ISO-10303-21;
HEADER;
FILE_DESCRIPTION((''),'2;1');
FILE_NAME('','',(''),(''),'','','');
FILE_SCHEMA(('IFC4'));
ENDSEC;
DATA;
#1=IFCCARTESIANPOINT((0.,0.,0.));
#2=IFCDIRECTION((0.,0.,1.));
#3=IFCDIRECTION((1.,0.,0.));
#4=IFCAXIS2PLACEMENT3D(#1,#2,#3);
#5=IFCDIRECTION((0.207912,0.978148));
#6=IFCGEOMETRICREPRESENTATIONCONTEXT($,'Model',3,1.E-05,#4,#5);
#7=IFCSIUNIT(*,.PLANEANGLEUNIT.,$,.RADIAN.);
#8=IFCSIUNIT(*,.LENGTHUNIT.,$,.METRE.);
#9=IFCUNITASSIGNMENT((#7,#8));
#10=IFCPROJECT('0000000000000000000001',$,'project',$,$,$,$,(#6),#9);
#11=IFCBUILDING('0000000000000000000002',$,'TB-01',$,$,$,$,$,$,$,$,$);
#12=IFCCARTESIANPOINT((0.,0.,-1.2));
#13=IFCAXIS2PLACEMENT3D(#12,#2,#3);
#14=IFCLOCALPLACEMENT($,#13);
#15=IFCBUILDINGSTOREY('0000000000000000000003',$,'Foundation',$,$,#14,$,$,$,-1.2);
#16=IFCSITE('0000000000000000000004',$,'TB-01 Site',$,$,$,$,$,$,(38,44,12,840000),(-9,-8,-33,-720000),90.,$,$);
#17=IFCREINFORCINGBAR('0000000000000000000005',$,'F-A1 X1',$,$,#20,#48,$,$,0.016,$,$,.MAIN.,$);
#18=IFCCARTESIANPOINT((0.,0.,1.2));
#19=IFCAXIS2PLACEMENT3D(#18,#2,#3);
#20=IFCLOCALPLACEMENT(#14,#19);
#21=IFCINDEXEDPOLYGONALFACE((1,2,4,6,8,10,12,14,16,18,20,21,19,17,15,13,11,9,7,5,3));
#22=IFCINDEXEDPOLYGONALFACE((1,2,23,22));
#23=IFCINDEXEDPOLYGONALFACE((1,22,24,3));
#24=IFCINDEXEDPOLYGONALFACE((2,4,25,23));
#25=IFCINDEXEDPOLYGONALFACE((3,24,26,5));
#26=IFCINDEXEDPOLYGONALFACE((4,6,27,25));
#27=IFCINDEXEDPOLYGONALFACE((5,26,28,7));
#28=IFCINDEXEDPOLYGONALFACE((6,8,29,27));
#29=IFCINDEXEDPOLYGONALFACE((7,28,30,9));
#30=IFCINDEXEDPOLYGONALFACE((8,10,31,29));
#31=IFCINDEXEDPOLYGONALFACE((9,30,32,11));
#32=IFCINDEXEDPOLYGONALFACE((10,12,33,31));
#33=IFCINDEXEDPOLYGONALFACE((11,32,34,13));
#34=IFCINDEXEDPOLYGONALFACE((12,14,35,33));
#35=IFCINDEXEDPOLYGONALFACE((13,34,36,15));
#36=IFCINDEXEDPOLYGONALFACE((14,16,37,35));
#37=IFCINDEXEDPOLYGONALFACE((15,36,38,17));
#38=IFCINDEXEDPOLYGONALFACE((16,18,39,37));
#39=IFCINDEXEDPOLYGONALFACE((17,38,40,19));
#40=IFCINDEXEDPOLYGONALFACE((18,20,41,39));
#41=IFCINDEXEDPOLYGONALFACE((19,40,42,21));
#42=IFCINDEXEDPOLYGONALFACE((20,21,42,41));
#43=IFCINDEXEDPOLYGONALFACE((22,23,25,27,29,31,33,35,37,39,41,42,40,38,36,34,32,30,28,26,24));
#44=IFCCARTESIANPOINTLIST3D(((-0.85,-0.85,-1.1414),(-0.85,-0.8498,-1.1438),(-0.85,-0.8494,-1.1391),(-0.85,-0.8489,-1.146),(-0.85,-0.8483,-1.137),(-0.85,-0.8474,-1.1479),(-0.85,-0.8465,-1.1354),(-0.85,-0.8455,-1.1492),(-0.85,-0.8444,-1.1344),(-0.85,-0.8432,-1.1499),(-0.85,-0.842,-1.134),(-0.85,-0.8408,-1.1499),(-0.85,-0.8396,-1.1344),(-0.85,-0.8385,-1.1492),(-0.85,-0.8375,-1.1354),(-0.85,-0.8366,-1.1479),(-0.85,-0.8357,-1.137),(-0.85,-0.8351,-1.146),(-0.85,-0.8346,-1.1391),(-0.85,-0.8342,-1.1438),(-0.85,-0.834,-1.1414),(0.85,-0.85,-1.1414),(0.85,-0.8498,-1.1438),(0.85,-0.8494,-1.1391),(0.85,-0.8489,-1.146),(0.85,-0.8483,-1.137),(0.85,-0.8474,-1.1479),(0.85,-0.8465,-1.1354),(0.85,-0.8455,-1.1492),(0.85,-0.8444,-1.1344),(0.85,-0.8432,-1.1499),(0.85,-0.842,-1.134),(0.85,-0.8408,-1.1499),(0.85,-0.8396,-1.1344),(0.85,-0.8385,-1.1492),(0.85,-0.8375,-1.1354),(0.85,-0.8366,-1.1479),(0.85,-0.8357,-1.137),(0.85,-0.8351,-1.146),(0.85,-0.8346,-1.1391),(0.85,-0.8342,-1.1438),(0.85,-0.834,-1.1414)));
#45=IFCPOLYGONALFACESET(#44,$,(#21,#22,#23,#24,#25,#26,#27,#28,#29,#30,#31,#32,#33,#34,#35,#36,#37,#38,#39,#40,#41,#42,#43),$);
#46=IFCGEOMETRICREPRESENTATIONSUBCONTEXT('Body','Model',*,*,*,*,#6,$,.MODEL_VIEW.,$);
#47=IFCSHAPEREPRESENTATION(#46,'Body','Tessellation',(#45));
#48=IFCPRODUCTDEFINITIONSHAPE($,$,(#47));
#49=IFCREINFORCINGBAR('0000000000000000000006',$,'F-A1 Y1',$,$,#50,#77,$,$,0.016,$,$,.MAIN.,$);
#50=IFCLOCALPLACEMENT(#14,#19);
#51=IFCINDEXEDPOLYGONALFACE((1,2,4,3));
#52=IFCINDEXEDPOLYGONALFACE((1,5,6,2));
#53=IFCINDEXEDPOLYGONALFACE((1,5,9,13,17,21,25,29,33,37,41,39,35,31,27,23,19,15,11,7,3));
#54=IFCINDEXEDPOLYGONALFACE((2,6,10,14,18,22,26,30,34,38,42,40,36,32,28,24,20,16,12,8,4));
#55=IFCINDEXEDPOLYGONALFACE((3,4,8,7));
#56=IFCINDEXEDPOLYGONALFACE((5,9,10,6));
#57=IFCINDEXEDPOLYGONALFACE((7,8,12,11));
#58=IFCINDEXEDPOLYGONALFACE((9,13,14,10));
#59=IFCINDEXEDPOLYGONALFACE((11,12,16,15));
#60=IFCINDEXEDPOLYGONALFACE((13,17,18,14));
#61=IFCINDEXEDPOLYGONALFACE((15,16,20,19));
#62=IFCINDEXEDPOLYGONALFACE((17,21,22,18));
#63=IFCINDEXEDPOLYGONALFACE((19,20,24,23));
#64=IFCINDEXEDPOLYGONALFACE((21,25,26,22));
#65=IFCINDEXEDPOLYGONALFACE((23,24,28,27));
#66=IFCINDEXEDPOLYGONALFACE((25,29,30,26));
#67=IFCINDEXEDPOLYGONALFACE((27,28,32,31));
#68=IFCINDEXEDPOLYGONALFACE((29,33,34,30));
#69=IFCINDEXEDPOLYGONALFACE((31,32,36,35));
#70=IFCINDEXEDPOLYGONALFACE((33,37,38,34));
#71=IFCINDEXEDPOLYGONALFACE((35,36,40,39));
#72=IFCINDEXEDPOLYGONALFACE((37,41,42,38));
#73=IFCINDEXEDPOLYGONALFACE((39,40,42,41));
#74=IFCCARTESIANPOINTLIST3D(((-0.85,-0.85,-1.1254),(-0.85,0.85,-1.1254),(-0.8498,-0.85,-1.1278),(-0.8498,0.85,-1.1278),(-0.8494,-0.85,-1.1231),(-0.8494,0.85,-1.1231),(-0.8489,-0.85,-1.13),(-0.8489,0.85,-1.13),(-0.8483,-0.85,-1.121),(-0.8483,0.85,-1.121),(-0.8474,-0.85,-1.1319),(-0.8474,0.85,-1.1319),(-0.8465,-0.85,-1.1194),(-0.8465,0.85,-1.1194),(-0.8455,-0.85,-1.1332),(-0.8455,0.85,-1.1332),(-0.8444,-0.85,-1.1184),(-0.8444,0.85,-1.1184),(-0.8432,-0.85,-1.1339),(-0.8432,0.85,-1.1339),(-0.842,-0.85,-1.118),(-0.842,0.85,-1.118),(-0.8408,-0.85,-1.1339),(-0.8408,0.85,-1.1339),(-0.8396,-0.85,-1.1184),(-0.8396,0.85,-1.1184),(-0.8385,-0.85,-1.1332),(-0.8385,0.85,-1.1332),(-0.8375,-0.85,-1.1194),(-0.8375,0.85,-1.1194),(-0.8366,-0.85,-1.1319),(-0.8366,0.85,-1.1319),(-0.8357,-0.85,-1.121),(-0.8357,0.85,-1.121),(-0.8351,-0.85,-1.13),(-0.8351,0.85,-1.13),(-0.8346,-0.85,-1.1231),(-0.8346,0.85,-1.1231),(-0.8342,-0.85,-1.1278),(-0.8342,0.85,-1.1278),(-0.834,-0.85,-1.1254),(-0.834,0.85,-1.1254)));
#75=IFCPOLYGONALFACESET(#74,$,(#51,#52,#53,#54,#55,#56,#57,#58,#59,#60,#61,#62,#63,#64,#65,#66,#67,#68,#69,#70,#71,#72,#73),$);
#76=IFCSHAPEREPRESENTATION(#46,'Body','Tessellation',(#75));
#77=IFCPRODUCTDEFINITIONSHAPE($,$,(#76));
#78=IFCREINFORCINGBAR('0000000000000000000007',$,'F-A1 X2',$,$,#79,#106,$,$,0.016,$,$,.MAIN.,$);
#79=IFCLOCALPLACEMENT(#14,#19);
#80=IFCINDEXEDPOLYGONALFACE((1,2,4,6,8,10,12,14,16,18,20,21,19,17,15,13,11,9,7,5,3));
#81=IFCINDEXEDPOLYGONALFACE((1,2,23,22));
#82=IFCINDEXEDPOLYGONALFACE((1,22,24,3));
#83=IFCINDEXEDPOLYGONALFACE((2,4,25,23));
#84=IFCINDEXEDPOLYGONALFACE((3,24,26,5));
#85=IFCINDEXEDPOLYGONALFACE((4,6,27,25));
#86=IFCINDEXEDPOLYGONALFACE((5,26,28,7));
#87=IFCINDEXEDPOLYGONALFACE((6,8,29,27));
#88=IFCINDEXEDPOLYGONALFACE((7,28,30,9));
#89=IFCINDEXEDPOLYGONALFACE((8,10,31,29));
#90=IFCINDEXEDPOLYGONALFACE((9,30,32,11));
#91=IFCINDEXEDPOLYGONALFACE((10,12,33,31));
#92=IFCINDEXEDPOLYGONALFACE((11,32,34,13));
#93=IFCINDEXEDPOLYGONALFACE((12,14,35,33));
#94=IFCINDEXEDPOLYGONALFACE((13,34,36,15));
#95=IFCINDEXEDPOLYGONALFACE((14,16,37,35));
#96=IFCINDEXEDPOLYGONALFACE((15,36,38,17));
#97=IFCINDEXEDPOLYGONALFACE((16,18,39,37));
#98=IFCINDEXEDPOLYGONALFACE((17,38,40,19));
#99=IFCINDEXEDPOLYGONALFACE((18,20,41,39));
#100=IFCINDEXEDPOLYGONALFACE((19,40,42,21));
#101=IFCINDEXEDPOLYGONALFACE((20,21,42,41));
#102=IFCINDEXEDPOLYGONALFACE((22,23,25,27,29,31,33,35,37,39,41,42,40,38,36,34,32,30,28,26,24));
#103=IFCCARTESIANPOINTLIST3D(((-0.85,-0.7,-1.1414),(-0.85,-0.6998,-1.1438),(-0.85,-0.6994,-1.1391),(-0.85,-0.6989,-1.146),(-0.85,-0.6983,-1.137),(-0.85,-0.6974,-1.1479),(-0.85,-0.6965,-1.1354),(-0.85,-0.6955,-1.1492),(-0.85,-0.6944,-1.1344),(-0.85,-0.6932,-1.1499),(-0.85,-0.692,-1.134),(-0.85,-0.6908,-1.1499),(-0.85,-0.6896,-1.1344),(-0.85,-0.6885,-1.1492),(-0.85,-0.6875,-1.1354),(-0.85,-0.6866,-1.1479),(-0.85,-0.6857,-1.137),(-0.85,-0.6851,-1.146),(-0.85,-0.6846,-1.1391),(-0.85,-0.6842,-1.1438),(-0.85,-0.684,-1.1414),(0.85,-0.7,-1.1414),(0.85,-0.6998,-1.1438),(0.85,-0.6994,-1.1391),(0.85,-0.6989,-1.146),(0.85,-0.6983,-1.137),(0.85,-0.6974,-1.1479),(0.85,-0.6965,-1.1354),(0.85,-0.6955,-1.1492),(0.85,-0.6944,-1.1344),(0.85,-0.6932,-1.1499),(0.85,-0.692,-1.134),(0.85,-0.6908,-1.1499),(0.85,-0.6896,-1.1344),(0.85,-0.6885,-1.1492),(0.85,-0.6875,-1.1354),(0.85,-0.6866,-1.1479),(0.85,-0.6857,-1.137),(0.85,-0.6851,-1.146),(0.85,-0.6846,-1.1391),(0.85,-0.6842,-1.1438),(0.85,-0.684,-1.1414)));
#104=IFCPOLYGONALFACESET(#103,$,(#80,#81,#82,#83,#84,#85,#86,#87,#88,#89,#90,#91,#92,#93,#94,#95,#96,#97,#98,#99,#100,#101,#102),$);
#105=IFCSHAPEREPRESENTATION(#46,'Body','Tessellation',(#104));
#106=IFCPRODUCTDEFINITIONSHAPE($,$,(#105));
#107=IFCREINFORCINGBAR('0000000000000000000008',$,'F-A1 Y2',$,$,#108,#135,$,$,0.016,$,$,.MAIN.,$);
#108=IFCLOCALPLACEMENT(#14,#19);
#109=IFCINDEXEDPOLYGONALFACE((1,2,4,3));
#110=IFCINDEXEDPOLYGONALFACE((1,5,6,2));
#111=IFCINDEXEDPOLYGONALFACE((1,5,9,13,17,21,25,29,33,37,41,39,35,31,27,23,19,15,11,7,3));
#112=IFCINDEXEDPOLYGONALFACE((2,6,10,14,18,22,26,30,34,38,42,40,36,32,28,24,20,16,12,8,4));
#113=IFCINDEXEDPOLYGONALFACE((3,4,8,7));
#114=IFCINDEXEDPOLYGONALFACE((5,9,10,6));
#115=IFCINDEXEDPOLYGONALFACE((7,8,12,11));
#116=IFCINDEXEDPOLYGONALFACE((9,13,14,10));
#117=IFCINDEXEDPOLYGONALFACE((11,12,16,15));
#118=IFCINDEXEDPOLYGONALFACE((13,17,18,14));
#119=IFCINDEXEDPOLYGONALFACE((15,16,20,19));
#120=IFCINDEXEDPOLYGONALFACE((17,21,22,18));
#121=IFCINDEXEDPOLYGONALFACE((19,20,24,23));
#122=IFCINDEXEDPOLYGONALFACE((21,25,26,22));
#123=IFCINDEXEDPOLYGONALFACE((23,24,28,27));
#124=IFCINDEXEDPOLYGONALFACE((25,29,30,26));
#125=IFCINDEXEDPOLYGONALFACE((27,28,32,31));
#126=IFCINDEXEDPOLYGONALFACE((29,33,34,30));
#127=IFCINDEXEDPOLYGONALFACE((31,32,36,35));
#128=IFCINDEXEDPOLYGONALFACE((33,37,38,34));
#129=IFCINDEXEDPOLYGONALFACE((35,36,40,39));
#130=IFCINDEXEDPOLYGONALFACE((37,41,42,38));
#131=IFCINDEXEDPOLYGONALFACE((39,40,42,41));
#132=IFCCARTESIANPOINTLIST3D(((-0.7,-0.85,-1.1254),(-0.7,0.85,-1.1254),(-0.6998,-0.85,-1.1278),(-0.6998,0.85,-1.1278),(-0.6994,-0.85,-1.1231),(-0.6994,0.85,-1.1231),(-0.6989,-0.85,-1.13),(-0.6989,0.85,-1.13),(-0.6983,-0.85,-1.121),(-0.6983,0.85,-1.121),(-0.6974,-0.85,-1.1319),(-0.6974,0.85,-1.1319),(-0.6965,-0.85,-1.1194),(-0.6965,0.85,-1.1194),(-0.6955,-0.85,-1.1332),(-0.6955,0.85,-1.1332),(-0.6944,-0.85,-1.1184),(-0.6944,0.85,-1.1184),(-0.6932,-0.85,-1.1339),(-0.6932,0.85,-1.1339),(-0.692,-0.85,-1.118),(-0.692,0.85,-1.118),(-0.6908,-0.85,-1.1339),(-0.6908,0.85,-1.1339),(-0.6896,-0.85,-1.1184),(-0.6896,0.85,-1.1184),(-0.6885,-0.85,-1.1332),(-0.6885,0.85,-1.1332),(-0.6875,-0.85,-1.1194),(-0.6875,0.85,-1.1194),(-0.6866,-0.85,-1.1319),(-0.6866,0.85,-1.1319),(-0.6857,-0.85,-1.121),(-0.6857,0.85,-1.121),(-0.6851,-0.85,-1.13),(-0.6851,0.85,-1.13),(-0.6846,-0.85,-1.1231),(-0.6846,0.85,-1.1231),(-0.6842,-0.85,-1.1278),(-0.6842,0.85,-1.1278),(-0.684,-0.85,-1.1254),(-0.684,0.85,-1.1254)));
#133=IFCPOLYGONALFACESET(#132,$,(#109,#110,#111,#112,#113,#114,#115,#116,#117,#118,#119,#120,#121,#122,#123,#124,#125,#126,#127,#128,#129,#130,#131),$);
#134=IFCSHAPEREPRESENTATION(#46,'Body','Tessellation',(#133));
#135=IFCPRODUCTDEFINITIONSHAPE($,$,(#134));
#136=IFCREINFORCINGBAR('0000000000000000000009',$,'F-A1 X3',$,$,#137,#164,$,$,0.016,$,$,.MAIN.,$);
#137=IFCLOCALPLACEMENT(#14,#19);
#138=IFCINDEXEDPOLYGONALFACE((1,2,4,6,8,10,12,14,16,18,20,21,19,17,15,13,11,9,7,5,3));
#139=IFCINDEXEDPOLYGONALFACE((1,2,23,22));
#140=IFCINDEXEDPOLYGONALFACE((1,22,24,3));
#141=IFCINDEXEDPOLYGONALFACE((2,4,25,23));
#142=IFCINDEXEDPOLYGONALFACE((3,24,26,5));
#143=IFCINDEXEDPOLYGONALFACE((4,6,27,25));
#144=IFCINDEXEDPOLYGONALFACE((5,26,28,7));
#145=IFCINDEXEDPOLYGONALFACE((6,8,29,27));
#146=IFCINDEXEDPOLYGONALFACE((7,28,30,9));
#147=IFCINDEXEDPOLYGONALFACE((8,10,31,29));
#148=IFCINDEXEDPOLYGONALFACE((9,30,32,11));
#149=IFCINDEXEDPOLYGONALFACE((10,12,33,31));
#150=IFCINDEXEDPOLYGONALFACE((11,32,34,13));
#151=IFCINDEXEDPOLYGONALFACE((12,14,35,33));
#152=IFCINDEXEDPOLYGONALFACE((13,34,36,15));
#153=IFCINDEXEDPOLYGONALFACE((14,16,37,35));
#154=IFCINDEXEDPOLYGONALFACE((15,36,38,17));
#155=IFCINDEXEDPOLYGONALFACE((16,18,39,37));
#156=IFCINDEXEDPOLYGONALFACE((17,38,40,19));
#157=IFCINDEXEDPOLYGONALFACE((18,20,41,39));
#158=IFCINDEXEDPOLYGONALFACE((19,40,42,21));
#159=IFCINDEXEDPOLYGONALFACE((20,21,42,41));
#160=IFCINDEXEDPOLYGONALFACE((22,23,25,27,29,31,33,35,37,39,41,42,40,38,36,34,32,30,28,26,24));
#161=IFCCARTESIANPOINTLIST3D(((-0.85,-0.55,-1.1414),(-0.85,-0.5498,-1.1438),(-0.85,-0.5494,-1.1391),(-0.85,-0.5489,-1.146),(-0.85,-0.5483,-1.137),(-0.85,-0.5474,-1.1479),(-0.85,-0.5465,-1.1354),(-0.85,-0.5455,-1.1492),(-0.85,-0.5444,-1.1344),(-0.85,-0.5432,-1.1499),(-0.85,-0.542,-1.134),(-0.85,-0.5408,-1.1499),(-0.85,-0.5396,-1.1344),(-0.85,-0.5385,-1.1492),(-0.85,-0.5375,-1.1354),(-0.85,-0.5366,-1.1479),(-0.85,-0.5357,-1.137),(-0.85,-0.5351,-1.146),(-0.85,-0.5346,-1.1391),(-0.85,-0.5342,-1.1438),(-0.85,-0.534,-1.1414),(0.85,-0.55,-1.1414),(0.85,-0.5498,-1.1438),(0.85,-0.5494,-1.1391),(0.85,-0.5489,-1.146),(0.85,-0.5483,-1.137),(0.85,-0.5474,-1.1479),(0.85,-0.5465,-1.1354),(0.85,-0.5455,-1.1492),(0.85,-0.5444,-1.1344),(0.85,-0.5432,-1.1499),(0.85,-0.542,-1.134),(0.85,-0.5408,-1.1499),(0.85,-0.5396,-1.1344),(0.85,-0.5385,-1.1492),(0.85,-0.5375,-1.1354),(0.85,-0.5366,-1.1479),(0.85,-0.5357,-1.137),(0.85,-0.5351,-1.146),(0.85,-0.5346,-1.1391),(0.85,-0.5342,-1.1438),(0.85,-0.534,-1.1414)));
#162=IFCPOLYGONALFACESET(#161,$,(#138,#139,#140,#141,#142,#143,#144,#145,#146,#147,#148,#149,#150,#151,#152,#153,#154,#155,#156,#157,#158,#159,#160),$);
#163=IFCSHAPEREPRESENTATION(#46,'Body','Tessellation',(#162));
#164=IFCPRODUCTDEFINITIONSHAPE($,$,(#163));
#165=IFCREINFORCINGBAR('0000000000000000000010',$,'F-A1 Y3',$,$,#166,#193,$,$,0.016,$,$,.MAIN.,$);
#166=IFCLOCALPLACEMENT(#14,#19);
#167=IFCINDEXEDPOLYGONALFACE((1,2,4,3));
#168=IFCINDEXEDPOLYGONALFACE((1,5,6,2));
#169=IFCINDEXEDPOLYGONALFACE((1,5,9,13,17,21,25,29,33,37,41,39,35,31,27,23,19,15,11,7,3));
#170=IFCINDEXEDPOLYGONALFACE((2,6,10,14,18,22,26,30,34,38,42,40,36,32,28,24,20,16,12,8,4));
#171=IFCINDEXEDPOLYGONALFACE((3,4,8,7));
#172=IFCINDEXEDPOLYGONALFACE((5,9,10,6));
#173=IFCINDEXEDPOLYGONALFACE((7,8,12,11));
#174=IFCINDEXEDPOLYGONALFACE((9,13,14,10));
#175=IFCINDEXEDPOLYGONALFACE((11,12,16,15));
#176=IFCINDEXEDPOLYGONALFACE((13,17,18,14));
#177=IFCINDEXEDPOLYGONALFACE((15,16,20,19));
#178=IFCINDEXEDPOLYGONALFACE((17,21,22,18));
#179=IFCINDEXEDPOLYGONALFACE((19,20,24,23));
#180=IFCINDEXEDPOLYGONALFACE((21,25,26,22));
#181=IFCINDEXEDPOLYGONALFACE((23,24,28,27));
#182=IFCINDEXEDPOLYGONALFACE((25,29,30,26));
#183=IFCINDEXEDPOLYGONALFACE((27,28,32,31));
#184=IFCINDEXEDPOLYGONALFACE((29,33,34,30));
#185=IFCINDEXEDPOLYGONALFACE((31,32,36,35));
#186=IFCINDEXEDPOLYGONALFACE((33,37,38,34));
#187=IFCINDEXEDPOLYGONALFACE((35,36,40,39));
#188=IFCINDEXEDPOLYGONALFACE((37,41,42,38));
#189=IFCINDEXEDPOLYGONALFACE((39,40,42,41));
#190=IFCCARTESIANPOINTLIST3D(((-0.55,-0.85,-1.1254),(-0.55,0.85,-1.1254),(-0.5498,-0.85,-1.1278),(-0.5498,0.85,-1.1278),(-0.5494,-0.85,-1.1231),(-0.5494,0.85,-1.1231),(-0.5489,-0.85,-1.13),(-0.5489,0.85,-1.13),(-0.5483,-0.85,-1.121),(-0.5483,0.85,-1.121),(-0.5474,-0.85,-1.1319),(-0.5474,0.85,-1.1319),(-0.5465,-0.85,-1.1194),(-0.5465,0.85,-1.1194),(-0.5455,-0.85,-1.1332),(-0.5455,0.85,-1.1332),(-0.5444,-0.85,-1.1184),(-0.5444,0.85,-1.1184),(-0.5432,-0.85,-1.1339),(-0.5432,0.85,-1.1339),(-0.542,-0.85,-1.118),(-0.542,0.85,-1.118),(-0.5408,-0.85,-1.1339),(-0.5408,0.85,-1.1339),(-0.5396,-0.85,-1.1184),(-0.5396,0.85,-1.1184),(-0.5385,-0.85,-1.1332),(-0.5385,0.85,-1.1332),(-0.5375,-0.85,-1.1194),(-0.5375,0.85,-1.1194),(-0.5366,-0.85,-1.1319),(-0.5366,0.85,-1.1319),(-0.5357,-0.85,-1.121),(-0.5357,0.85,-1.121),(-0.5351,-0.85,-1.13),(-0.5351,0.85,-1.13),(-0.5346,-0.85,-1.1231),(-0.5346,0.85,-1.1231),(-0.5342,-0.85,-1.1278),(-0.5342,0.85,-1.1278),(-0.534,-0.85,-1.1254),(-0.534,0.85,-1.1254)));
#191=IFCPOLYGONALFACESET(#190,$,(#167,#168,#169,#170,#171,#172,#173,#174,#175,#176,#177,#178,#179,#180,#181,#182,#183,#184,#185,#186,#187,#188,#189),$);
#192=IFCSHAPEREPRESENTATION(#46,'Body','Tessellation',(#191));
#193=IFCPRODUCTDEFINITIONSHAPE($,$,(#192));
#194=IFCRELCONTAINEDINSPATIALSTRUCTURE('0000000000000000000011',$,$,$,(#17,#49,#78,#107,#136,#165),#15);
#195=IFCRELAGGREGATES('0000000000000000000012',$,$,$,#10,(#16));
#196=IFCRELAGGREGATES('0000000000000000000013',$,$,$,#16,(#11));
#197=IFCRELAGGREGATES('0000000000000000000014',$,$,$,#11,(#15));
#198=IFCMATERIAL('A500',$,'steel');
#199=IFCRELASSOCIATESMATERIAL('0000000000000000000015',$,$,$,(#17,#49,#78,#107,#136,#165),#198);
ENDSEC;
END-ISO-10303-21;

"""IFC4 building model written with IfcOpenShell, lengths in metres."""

from ifc_helpers import new_model, entity, si_unit, direction, frame, origin_with_axes, place, context, subcontext, project, spatial, material, element, save


model = new_model("IFC4")

# Units and contexts
model_context = context("Model", 3, precision=1e-05, world=origin_with_axes(), true_north=direction((0.207912, 0.978148)))
body_context = subcontext(model_context, "Body", "Model", "MODEL_VIEW")
ifc_project = project(units=[si_unit("PLANEANGLEUNIT", "RADIAN"), si_unit("LENGTHUNIT", "METRE")], contexts=[model_context])

# Site, building, storey
site = spatial("IfcSite", under=ifc_project, Name="TB-01 Site", RefLatitude=(38, 44, 12, 840000), RefLongitude=(-9, -8, -33, -720000), RefElevation=90.0)
building = spatial("IfcBuilding", under=site, Name="TB-01")
storey_placement = place(None, frame((0.0, 0.0, -1.2), z_axis=(0.0, 0.0, 1.0), x_axis=(1.0, 0.0, 0.0)))
storey = spatial("IfcBuildingStorey", under=building, at=storey_placement, Name="Foundation", Elevation=-1.2)

# Reinforcing bars
ifc_material_1 = material(Name="A500", Category="steel")
reinforcing_bar_1_placement = place(storey_placement, frame((0.0, 0.0, 1.2), z_axis=(0.0, 0.0, 1.0), x_axis=(1.0, 0.0, 0.0)))
element("IfcReinforcingBar", 1, at=reinforcing_bar_1_placement, inside=storey, material=ifc_material_1, Name="F-A1 X1", NominalDiameter=0.016, PredefinedType="MAIN", context=body_context, shape_type="AdvancedSweptSolid", body=[
    entity("IfcSweptDiskSolid", entity("IfcPolyline", [entity("IfcCartesianPoint", [-0.85, -0.842, -1.142]), entity("IfcCartesianPoint", [0.85, -0.842, -1.142])]), 0.008),
])
reinforcing_bar_2_placement = place(storey_placement, frame((0.0, 0.0, 1.2), z_axis=(0.0, 0.0, 1.0), x_axis=(1.0, 0.0, 0.0)))
element("IfcReinforcingBar", 2, at=reinforcing_bar_2_placement, inside=storey, material=ifc_material_1, Name="F-A1 Y1", NominalDiameter=0.016, PredefinedType="MAIN", context=body_context, shape_type="AdvancedSweptSolid", body=[
    entity("IfcSweptDiskSolid", entity("IfcPolyline", [entity("IfcCartesianPoint", [-0.842, -0.85, -1.126]), entity("IfcCartesianPoint", [-0.842, 0.85, -1.126])]), 0.008),
])
reinforcing_bar_3_placement = place(storey_placement, frame((0.0, 0.0, 1.2), z_axis=(0.0, 0.0, 1.0), x_axis=(1.0, 0.0, 0.0)))
element("IfcReinforcingBar", 3, at=reinforcing_bar_3_placement, inside=storey, material=ifc_material_1, Name="F-A1 X2", NominalDiameter=0.016, PredefinedType="MAIN", context=body_context, shape_type="AdvancedSweptSolid", body=[
    entity("IfcSweptDiskSolid", entity("IfcPolyline", [entity("IfcCartesianPoint", [-0.85, -0.692, -1.142]), entity("IfcCartesianPoint", [0.85, -0.692, -1.142])]), 0.008),
])
reinforcing_bar_4_placement = place(storey_placement, frame((0.0, 0.0, 1.2), z_axis=(0.0, 0.0, 1.0), x_axis=(1.0, 0.0, 0.0)))
element("IfcReinforcingBar", 4, at=reinforcing_bar_4_placement, inside=storey, material=ifc_material_1, Name="F-A1 Y2", NominalDiameter=0.016, PredefinedType="MAIN", context=body_context, shape_type="AdvancedSweptSolid", body=[
    entity("IfcSweptDiskSolid", entity("IfcPolyline", [entity("IfcCartesianPoint", [-0.692, -0.85, -1.126]), entity("IfcCartesianPoint", [-0.692, 0.85, -1.126])]), 0.008),
])
reinforcing_bar_5_placement = place(storey_placement, frame((0.0, 0.0, 1.2), z_axis=(0.0, 0.0, 1.0), x_axis=(1.0, 0.0, 0.0)))
element("IfcReinforcingBar", 5, at=reinforcing_bar_5_placement, inside=storey, material=ifc_material_1, Name="F-A1 X3", NominalDiameter=0.016, PredefinedType="MAIN", context=body_context, shape_type="AdvancedSweptSolid", body=[
    entity("IfcSweptDiskSolid", entity("IfcPolyline", [entity("IfcCartesianPoint", [-0.85, -0.542, -1.142]), entity("IfcCartesianPoint", [0.85, -0.542, -1.142])]), 0.008),
])
reinforcing_bar_6_placement = place(storey_placement, frame((0.0, 0.0, 1.2), z_axis=(0.0, 0.0, 1.0), x_axis=(1.0, 0.0, 0.0)))
element("IfcReinforcingBar", 6, at=reinforcing_bar_6_placement, inside=storey, material=ifc_material_1, Name="F-A1 Y3", NominalDiameter=0.016, PredefinedType="MAIN", context=body_context, shape_type="AdvancedSweptSolid", body=[
    entity("IfcSweptDiskSolid", entity("IfcPolyline", [entity("IfcCartesianPoint", [-0.542, -0.85, -1.126]), entity("IfcCartesianPoint", [-0.542, 0.85, -1.126])]), 0.008),
])

save(model, "model.ifc")
